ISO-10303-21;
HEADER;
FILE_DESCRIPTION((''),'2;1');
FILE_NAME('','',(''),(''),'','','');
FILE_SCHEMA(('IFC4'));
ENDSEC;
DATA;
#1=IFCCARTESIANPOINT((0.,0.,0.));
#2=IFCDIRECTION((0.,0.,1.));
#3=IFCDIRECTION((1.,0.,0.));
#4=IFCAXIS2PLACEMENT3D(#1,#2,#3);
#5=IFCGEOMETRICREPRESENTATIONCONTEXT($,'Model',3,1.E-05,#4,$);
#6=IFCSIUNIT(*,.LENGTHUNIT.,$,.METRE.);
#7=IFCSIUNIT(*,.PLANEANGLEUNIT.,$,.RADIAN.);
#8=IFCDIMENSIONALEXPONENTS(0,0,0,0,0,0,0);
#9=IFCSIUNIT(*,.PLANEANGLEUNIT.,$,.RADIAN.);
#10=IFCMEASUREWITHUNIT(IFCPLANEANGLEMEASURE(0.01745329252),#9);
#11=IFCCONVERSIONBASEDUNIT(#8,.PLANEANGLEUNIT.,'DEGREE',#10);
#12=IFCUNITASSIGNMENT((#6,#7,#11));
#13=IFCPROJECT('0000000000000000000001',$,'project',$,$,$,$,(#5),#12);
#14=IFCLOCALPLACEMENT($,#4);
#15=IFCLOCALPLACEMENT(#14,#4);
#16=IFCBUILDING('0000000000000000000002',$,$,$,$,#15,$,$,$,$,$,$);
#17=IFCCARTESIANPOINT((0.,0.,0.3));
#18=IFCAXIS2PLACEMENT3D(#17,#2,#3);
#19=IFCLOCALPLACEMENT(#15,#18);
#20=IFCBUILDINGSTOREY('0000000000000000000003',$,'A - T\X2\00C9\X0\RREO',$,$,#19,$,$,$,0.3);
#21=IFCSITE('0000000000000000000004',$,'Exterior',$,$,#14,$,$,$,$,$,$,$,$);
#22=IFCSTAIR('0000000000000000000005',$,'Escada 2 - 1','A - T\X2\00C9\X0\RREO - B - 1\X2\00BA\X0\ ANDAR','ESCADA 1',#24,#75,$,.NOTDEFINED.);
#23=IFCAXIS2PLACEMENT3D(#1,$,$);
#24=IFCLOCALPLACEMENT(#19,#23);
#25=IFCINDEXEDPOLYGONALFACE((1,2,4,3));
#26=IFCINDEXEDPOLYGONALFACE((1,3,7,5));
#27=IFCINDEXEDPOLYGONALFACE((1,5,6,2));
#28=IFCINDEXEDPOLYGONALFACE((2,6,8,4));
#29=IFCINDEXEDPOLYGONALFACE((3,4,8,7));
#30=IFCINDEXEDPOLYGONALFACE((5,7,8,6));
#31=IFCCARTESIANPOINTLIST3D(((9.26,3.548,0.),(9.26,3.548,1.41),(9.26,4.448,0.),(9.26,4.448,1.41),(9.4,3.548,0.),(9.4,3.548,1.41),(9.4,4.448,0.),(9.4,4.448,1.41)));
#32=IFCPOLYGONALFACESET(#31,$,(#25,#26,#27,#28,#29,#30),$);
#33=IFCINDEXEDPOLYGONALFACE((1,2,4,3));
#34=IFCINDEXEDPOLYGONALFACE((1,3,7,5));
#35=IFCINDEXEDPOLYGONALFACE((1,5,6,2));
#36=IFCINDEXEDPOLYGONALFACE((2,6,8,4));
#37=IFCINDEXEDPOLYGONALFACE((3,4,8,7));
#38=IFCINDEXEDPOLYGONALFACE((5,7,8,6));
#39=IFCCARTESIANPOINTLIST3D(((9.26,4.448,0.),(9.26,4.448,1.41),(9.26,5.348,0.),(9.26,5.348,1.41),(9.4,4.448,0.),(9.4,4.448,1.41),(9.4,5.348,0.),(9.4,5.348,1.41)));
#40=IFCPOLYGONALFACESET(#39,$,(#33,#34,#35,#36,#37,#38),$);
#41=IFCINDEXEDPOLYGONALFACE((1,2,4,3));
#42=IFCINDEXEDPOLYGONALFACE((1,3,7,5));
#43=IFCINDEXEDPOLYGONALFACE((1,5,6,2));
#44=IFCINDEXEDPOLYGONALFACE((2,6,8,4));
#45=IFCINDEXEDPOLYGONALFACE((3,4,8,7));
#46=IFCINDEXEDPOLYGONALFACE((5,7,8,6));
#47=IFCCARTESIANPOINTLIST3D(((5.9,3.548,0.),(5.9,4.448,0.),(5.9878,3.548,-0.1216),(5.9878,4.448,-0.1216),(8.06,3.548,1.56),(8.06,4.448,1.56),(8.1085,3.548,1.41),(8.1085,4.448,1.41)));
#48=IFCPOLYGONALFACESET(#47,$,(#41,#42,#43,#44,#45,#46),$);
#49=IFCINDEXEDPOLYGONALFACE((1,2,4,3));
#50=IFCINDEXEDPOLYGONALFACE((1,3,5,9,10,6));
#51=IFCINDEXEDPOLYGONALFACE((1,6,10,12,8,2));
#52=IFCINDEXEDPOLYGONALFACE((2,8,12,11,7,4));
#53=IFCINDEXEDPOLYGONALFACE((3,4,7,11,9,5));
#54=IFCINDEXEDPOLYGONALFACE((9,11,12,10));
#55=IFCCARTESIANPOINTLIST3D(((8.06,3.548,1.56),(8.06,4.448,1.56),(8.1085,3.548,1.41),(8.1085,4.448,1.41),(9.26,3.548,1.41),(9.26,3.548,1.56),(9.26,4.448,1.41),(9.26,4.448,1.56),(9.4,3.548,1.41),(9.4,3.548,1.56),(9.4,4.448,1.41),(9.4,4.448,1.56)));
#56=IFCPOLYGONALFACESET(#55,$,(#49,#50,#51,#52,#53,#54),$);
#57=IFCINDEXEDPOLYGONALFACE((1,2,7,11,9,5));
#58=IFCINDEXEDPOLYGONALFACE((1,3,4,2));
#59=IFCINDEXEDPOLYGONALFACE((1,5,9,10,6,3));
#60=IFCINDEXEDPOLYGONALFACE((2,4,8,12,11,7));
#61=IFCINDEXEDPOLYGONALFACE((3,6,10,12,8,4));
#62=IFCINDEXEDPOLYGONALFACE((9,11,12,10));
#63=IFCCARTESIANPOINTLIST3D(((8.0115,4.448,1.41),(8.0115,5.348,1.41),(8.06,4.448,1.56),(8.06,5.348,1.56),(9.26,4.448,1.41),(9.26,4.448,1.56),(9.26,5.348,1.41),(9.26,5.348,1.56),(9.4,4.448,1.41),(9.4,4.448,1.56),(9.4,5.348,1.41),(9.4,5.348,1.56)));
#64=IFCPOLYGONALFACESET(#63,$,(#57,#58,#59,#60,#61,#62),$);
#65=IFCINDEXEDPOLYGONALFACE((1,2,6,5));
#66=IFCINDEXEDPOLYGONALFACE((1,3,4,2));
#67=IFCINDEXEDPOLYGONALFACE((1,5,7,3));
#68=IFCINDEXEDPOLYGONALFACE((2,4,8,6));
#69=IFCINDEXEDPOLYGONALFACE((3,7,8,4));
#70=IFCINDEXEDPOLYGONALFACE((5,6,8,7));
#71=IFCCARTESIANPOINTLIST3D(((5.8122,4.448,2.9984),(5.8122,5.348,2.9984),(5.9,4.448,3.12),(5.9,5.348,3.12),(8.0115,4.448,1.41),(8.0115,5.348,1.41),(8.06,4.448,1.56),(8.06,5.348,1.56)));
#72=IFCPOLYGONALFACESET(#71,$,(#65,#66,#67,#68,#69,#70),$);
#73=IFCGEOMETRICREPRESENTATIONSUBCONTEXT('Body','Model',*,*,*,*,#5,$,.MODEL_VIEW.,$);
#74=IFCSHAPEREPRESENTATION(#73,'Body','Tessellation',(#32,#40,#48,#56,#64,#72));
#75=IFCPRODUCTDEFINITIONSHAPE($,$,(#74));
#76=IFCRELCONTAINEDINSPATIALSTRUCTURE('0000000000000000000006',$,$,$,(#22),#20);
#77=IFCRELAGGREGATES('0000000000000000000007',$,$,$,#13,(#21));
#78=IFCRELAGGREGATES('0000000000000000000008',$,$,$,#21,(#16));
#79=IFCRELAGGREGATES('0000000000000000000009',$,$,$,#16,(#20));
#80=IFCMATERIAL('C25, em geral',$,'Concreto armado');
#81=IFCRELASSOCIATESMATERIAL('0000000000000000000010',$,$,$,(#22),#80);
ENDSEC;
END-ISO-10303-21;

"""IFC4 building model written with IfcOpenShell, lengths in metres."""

from ifc_helpers import new_model, entity, si_unit, converted_unit, frame, origin_with_axes, place, context, subcontext, project, spatial, material, element, save


model = new_model("IFC4")

# Units and contexts
model_context = context("Model", 3, precision=1e-05, world=origin_with_axes())
body_context = subcontext(model_context, "Body", "Model", "MODEL_VIEW")
ifc_project = project(units=[si_unit("LENGTHUNIT", "METRE"), si_unit("PLANEANGLEUNIT", "RADIAN"), converted_unit("PLANEANGLEUNIT", "DEGREE", entity("IfcPlaneAngleMeasure", 0.01745329252), si_unit("PLANEANGLEUNIT", "RADIAN"), dimensions=[0, 0, 0, 0, 0, 0, 0])], contexts=[model_context])

# Site, building, storey
site_placement = place(None, origin_with_axes())
site = spatial("IfcSite", under=ifc_project, at=site_placement, Name="Exterior")
building_placement = place(site_placement, origin_with_axes())
building = spatial("IfcBuilding", under=site, at=building_placement)
storey_placement = place(building_placement, frame((0.0, 0.0, 0.3), z_axis=(0.0, 0.0, 1.0), x_axis=(1.0, 0.0, 0.0)))
storey = spatial("IfcBuildingStorey", under=building, at=storey_placement, Name="A - TÉRREO", Elevation=0.3)

# Shared definitions
ifc_material = material(Name="C25, em geral", Category="Concreto armado")

# Stair
stair_placement = place(storey_placement, frame((5.9, 3.998, 0.0), z_axis=(0.0, 0.0, 1.0), x_axis=(1.0, 0.0, 0.0)))
cartesian_point_1 = entity("IfcCartesianPoint", [-0.705, -0.45])
cartesian_point_2 = entity("IfcCartesianPoint", [-0.705, -0.45])
cartesian_point_3 = entity("IfcCartesianPoint", [-0.705, -0.45])
cartesian_point_4 = entity("IfcCartesianPoint", [-0.705, -0.45])
cartesian_point_5 = entity("IfcCartesianPoint", [-0.45, 1.308])
cartesian_point_6 = entity("IfcCartesianPoint", [-0.45, 1.3322])
cartesian_point_7 = entity("IfcCartesianPoint", [-0.6457, -0.45])
cartesian_point_8 = entity("IfcCartesianPoint", [-0.67, -0.45])
cartesian_point_9 = entity("IfcCartesianPoint", [0.5543, -0.45])
cartesian_point_10 = entity("IfcCartesianPoint", [0.53, -0.45])
cartesian_point_11 = entity("IfcCartesianPoint", [0.45, -1.3565])
cartesian_point_12 = entity("IfcCartesianPoint", [0.45, -1.3322])
element("IfcStair", 1, at=stair_placement, inside=storey, material=ifc_material, Name="Escada 2 - 1", Description="A - TÉRREO - B - 1º ANDAR", ObjectType="ESCADA 1", PredefinedType="NOTDEFINED", context=body_context, shape_type="SolidModel", body=[
    entity("IfcExtrudedAreaSolidTapered", entity("IfcArbitraryClosedProfileDef", "AREA", None, entity("IfcPolyline", [cartesian_point_1, entity("IfcCartesianPoint", [0.705, -0.45]), entity("IfcCartesianPoint", [0.705, 0.45]), entity("IfcCartesianPoint", [-0.705, 0.45]), cartesian_point_1])), entity("IfcAxis2Placement3D", entity("IfcCartesianPoint", [3.36, 0.0, 0.705]), entity("IfcDirection", [1.0, 0.0, 0.0]), entity("IfcDirection", [0.0, 0.0, -1.0])), entity("IfcDirection", [0.0, 0.0, 1.0]), 0.14, entity("IfcArbitraryClosedProfileDef", "AREA", None, entity("IfcPolyline", [cartesian_point_2, entity("IfcCartesianPoint", [0.705, -0.45]), entity("IfcCartesianPoint", [0.705, 0.45]), entity("IfcCartesianPoint", [-0.705, 0.45]), cartesian_point_2]))),
    entity("IfcExtrudedAreaSolidTapered", entity("IfcArbitraryClosedProfileDef", "AREA", None, entity("IfcPolyline", [cartesian_point_3, entity("IfcCartesianPoint", [0.705, -0.45]), entity("IfcCartesianPoint", [0.705, 0.45]), entity("IfcCartesianPoint", [-0.705, 0.45]), cartesian_point_3])), entity("IfcAxis2Placement3D", entity("IfcCartesianPoint", [3.36, 0.9, 0.705]), entity("IfcDirection", [1.0, 0.0, 0.0]), entity("IfcDirection", [0.0, 0.0, -1.0])), entity("IfcDirection", [0.0, 0.0, 1.0]), 0.14, entity("IfcArbitraryClosedProfileDef", "AREA", None, entity("IfcPolyline", [cartesian_point_4, entity("IfcCartesianPoint", [0.705, -0.45]), entity("IfcCartesianPoint", [0.705, 0.45]), entity("IfcCartesianPoint", [-0.705, 0.45]), cartesian_point_4]))),
    entity("IfcExtrudedAreaSolidTapered", entity("IfcArbitraryClosedProfileDef", "AREA", None, entity("IfcPolyline", [cartesian_point_5, entity("IfcCartesianPoint", [-0.45, -1.308]), entity("IfcCartesianPoint", [0.45, -1.308]), entity("IfcCartesianPoint", [0.45, 1.308]), cartesian_point_5])), entity("IfcAxis2Placement3D", entity("IfcCartesianPoint", [1.1482, 0.0, 0.6442]), entity("IfcDirection", [-0.585491, 0.0, 0.810679]), entity("IfcDirection", [0.0, 1.0, 0.0])), entity("IfcDirection", [0.0, -0.159605, 0.987181]), 0.1519, entity("IfcArbitraryClosedProfileDef", "AREA", None, entity("IfcPolyline", [cartesian_point_6, entity("IfcCartesianPoint", [-0.45, -1.3322]), entity("IfcCartesianPoint", [0.45, -1.3322]), entity("IfcCartesianPoint", [0.45, 1.3322]), cartesian_point_6]))),
    entity("IfcExtrudedAreaSolidTapered", entity("IfcArbitraryClosedProfileDef", "AREA", None, entity("IfcPolyline", [cartesian_point_7, entity("IfcCartesianPoint", [0.5057, -0.45]), entity("IfcCartesianPoint", [0.6457, -0.45]), entity("IfcCartesianPoint", [0.6457, 0.45]), entity("IfcCartesianPoint", [0.5057, 0.45]), entity("IfcCartesianPoint", [-0.6457, 0.45]), cartesian_point_7])), entity("IfcAxis2Placement3D", entity("IfcCartesianPoint", [2.8543, 0.0, 1.41]), entity("IfcDirection", [0.0, 0.0, 1.0]), entity("IfcDirection", [1.0, 0.0, 0.0])), entity("IfcDirection", [-0.159605, 0.0, 0.987181]), 0.1519, entity("IfcArbitraryClosedProfileDef", "AREA", None, entity("IfcPolyline", [cartesian_point_8, entity("IfcCartesianPoint", [0.53, -0.45]), entity("IfcCartesianPoint", [0.67, -0.45]), entity("IfcCartesianPoint", [0.67, 0.45]), entity("IfcCartesianPoint", [0.53, 0.45]), entity("IfcCartesianPoint", [-0.67, 0.45]), cartesian_point_8]))),
    entity("IfcExtrudedAreaSolidTapered", entity("IfcArbitraryClosedProfileDef", "AREA", None, entity("IfcPolyline", [cartesian_point_9, entity("IfcCartesianPoint", [0.6943, -0.45]), entity("IfcCartesianPoint", [0.6943, 0.45]), entity("IfcCartesianPoint", [0.5543, 0.45]), entity("IfcCartesianPoint", [-0.6943, 0.45]), entity("IfcCartesianPoint", [-0.6943, -0.45]), cartesian_point_9])), entity("IfcAxis2Placement3D", entity("IfcCartesianPoint", [2.8057, 0.9, 1.41]), entity("IfcDirection", [0.0, 0.0, 1.0]), entity("IfcDirection", [1.0, 0.0, 0.0])), entity("IfcDirection", [0.159605, 0.0, 0.987181]), 0.1519, entity("IfcArbitraryClosedProfileDef", "AREA", None, entity("IfcPolyline", [cartesian_point_10, entity("IfcCartesianPoint", [0.67, -0.45]), entity("IfcCartesianPoint", [0.67, 0.45]), entity("IfcCartesianPoint", [0.53, 0.45]), entity("IfcCartesianPoint", [-0.67, 0.45]), entity("IfcCartesianPoint", [-0.67, -0.45]), cartesian_point_10]))),
    entity("IfcExtrudedAreaSolidTapered", entity("IfcArbitraryClosedProfileDef", "AREA", None, entity("IfcPolyline", [cartesian_point_11, entity("IfcCartesianPoint", [0.45, 1.3565]), entity("IfcCartesianPoint", [-0.45, 1.3565]), entity("IfcCartesianPoint", [-0.45, -1.3565]), cartesian_point_11])), entity("IfcAxis2Placement3D", entity("IfcCartesianPoint", [1.0118, 0.9, 2.2042]), entity("IfcDirection", [0.585491, 0.0, 0.810679]), entity("IfcDirection", [0.0, 1.0, 0.0])), entity("IfcDirection", [0.0, 0.159605, 0.987181]), 0.1519, entity("IfcArbitraryClosedProfileDef", "AREA", None, entity("IfcPolyline", [cartesian_point_12, entity("IfcCartesianPoint", [0.45, 1.3322]), entity("IfcCartesianPoint", [-0.45, 1.3322]), entity("IfcCartesianPoint", [-0.45, -1.3322]), cartesian_point_12]))),
])

save(model, "model.ifc")
